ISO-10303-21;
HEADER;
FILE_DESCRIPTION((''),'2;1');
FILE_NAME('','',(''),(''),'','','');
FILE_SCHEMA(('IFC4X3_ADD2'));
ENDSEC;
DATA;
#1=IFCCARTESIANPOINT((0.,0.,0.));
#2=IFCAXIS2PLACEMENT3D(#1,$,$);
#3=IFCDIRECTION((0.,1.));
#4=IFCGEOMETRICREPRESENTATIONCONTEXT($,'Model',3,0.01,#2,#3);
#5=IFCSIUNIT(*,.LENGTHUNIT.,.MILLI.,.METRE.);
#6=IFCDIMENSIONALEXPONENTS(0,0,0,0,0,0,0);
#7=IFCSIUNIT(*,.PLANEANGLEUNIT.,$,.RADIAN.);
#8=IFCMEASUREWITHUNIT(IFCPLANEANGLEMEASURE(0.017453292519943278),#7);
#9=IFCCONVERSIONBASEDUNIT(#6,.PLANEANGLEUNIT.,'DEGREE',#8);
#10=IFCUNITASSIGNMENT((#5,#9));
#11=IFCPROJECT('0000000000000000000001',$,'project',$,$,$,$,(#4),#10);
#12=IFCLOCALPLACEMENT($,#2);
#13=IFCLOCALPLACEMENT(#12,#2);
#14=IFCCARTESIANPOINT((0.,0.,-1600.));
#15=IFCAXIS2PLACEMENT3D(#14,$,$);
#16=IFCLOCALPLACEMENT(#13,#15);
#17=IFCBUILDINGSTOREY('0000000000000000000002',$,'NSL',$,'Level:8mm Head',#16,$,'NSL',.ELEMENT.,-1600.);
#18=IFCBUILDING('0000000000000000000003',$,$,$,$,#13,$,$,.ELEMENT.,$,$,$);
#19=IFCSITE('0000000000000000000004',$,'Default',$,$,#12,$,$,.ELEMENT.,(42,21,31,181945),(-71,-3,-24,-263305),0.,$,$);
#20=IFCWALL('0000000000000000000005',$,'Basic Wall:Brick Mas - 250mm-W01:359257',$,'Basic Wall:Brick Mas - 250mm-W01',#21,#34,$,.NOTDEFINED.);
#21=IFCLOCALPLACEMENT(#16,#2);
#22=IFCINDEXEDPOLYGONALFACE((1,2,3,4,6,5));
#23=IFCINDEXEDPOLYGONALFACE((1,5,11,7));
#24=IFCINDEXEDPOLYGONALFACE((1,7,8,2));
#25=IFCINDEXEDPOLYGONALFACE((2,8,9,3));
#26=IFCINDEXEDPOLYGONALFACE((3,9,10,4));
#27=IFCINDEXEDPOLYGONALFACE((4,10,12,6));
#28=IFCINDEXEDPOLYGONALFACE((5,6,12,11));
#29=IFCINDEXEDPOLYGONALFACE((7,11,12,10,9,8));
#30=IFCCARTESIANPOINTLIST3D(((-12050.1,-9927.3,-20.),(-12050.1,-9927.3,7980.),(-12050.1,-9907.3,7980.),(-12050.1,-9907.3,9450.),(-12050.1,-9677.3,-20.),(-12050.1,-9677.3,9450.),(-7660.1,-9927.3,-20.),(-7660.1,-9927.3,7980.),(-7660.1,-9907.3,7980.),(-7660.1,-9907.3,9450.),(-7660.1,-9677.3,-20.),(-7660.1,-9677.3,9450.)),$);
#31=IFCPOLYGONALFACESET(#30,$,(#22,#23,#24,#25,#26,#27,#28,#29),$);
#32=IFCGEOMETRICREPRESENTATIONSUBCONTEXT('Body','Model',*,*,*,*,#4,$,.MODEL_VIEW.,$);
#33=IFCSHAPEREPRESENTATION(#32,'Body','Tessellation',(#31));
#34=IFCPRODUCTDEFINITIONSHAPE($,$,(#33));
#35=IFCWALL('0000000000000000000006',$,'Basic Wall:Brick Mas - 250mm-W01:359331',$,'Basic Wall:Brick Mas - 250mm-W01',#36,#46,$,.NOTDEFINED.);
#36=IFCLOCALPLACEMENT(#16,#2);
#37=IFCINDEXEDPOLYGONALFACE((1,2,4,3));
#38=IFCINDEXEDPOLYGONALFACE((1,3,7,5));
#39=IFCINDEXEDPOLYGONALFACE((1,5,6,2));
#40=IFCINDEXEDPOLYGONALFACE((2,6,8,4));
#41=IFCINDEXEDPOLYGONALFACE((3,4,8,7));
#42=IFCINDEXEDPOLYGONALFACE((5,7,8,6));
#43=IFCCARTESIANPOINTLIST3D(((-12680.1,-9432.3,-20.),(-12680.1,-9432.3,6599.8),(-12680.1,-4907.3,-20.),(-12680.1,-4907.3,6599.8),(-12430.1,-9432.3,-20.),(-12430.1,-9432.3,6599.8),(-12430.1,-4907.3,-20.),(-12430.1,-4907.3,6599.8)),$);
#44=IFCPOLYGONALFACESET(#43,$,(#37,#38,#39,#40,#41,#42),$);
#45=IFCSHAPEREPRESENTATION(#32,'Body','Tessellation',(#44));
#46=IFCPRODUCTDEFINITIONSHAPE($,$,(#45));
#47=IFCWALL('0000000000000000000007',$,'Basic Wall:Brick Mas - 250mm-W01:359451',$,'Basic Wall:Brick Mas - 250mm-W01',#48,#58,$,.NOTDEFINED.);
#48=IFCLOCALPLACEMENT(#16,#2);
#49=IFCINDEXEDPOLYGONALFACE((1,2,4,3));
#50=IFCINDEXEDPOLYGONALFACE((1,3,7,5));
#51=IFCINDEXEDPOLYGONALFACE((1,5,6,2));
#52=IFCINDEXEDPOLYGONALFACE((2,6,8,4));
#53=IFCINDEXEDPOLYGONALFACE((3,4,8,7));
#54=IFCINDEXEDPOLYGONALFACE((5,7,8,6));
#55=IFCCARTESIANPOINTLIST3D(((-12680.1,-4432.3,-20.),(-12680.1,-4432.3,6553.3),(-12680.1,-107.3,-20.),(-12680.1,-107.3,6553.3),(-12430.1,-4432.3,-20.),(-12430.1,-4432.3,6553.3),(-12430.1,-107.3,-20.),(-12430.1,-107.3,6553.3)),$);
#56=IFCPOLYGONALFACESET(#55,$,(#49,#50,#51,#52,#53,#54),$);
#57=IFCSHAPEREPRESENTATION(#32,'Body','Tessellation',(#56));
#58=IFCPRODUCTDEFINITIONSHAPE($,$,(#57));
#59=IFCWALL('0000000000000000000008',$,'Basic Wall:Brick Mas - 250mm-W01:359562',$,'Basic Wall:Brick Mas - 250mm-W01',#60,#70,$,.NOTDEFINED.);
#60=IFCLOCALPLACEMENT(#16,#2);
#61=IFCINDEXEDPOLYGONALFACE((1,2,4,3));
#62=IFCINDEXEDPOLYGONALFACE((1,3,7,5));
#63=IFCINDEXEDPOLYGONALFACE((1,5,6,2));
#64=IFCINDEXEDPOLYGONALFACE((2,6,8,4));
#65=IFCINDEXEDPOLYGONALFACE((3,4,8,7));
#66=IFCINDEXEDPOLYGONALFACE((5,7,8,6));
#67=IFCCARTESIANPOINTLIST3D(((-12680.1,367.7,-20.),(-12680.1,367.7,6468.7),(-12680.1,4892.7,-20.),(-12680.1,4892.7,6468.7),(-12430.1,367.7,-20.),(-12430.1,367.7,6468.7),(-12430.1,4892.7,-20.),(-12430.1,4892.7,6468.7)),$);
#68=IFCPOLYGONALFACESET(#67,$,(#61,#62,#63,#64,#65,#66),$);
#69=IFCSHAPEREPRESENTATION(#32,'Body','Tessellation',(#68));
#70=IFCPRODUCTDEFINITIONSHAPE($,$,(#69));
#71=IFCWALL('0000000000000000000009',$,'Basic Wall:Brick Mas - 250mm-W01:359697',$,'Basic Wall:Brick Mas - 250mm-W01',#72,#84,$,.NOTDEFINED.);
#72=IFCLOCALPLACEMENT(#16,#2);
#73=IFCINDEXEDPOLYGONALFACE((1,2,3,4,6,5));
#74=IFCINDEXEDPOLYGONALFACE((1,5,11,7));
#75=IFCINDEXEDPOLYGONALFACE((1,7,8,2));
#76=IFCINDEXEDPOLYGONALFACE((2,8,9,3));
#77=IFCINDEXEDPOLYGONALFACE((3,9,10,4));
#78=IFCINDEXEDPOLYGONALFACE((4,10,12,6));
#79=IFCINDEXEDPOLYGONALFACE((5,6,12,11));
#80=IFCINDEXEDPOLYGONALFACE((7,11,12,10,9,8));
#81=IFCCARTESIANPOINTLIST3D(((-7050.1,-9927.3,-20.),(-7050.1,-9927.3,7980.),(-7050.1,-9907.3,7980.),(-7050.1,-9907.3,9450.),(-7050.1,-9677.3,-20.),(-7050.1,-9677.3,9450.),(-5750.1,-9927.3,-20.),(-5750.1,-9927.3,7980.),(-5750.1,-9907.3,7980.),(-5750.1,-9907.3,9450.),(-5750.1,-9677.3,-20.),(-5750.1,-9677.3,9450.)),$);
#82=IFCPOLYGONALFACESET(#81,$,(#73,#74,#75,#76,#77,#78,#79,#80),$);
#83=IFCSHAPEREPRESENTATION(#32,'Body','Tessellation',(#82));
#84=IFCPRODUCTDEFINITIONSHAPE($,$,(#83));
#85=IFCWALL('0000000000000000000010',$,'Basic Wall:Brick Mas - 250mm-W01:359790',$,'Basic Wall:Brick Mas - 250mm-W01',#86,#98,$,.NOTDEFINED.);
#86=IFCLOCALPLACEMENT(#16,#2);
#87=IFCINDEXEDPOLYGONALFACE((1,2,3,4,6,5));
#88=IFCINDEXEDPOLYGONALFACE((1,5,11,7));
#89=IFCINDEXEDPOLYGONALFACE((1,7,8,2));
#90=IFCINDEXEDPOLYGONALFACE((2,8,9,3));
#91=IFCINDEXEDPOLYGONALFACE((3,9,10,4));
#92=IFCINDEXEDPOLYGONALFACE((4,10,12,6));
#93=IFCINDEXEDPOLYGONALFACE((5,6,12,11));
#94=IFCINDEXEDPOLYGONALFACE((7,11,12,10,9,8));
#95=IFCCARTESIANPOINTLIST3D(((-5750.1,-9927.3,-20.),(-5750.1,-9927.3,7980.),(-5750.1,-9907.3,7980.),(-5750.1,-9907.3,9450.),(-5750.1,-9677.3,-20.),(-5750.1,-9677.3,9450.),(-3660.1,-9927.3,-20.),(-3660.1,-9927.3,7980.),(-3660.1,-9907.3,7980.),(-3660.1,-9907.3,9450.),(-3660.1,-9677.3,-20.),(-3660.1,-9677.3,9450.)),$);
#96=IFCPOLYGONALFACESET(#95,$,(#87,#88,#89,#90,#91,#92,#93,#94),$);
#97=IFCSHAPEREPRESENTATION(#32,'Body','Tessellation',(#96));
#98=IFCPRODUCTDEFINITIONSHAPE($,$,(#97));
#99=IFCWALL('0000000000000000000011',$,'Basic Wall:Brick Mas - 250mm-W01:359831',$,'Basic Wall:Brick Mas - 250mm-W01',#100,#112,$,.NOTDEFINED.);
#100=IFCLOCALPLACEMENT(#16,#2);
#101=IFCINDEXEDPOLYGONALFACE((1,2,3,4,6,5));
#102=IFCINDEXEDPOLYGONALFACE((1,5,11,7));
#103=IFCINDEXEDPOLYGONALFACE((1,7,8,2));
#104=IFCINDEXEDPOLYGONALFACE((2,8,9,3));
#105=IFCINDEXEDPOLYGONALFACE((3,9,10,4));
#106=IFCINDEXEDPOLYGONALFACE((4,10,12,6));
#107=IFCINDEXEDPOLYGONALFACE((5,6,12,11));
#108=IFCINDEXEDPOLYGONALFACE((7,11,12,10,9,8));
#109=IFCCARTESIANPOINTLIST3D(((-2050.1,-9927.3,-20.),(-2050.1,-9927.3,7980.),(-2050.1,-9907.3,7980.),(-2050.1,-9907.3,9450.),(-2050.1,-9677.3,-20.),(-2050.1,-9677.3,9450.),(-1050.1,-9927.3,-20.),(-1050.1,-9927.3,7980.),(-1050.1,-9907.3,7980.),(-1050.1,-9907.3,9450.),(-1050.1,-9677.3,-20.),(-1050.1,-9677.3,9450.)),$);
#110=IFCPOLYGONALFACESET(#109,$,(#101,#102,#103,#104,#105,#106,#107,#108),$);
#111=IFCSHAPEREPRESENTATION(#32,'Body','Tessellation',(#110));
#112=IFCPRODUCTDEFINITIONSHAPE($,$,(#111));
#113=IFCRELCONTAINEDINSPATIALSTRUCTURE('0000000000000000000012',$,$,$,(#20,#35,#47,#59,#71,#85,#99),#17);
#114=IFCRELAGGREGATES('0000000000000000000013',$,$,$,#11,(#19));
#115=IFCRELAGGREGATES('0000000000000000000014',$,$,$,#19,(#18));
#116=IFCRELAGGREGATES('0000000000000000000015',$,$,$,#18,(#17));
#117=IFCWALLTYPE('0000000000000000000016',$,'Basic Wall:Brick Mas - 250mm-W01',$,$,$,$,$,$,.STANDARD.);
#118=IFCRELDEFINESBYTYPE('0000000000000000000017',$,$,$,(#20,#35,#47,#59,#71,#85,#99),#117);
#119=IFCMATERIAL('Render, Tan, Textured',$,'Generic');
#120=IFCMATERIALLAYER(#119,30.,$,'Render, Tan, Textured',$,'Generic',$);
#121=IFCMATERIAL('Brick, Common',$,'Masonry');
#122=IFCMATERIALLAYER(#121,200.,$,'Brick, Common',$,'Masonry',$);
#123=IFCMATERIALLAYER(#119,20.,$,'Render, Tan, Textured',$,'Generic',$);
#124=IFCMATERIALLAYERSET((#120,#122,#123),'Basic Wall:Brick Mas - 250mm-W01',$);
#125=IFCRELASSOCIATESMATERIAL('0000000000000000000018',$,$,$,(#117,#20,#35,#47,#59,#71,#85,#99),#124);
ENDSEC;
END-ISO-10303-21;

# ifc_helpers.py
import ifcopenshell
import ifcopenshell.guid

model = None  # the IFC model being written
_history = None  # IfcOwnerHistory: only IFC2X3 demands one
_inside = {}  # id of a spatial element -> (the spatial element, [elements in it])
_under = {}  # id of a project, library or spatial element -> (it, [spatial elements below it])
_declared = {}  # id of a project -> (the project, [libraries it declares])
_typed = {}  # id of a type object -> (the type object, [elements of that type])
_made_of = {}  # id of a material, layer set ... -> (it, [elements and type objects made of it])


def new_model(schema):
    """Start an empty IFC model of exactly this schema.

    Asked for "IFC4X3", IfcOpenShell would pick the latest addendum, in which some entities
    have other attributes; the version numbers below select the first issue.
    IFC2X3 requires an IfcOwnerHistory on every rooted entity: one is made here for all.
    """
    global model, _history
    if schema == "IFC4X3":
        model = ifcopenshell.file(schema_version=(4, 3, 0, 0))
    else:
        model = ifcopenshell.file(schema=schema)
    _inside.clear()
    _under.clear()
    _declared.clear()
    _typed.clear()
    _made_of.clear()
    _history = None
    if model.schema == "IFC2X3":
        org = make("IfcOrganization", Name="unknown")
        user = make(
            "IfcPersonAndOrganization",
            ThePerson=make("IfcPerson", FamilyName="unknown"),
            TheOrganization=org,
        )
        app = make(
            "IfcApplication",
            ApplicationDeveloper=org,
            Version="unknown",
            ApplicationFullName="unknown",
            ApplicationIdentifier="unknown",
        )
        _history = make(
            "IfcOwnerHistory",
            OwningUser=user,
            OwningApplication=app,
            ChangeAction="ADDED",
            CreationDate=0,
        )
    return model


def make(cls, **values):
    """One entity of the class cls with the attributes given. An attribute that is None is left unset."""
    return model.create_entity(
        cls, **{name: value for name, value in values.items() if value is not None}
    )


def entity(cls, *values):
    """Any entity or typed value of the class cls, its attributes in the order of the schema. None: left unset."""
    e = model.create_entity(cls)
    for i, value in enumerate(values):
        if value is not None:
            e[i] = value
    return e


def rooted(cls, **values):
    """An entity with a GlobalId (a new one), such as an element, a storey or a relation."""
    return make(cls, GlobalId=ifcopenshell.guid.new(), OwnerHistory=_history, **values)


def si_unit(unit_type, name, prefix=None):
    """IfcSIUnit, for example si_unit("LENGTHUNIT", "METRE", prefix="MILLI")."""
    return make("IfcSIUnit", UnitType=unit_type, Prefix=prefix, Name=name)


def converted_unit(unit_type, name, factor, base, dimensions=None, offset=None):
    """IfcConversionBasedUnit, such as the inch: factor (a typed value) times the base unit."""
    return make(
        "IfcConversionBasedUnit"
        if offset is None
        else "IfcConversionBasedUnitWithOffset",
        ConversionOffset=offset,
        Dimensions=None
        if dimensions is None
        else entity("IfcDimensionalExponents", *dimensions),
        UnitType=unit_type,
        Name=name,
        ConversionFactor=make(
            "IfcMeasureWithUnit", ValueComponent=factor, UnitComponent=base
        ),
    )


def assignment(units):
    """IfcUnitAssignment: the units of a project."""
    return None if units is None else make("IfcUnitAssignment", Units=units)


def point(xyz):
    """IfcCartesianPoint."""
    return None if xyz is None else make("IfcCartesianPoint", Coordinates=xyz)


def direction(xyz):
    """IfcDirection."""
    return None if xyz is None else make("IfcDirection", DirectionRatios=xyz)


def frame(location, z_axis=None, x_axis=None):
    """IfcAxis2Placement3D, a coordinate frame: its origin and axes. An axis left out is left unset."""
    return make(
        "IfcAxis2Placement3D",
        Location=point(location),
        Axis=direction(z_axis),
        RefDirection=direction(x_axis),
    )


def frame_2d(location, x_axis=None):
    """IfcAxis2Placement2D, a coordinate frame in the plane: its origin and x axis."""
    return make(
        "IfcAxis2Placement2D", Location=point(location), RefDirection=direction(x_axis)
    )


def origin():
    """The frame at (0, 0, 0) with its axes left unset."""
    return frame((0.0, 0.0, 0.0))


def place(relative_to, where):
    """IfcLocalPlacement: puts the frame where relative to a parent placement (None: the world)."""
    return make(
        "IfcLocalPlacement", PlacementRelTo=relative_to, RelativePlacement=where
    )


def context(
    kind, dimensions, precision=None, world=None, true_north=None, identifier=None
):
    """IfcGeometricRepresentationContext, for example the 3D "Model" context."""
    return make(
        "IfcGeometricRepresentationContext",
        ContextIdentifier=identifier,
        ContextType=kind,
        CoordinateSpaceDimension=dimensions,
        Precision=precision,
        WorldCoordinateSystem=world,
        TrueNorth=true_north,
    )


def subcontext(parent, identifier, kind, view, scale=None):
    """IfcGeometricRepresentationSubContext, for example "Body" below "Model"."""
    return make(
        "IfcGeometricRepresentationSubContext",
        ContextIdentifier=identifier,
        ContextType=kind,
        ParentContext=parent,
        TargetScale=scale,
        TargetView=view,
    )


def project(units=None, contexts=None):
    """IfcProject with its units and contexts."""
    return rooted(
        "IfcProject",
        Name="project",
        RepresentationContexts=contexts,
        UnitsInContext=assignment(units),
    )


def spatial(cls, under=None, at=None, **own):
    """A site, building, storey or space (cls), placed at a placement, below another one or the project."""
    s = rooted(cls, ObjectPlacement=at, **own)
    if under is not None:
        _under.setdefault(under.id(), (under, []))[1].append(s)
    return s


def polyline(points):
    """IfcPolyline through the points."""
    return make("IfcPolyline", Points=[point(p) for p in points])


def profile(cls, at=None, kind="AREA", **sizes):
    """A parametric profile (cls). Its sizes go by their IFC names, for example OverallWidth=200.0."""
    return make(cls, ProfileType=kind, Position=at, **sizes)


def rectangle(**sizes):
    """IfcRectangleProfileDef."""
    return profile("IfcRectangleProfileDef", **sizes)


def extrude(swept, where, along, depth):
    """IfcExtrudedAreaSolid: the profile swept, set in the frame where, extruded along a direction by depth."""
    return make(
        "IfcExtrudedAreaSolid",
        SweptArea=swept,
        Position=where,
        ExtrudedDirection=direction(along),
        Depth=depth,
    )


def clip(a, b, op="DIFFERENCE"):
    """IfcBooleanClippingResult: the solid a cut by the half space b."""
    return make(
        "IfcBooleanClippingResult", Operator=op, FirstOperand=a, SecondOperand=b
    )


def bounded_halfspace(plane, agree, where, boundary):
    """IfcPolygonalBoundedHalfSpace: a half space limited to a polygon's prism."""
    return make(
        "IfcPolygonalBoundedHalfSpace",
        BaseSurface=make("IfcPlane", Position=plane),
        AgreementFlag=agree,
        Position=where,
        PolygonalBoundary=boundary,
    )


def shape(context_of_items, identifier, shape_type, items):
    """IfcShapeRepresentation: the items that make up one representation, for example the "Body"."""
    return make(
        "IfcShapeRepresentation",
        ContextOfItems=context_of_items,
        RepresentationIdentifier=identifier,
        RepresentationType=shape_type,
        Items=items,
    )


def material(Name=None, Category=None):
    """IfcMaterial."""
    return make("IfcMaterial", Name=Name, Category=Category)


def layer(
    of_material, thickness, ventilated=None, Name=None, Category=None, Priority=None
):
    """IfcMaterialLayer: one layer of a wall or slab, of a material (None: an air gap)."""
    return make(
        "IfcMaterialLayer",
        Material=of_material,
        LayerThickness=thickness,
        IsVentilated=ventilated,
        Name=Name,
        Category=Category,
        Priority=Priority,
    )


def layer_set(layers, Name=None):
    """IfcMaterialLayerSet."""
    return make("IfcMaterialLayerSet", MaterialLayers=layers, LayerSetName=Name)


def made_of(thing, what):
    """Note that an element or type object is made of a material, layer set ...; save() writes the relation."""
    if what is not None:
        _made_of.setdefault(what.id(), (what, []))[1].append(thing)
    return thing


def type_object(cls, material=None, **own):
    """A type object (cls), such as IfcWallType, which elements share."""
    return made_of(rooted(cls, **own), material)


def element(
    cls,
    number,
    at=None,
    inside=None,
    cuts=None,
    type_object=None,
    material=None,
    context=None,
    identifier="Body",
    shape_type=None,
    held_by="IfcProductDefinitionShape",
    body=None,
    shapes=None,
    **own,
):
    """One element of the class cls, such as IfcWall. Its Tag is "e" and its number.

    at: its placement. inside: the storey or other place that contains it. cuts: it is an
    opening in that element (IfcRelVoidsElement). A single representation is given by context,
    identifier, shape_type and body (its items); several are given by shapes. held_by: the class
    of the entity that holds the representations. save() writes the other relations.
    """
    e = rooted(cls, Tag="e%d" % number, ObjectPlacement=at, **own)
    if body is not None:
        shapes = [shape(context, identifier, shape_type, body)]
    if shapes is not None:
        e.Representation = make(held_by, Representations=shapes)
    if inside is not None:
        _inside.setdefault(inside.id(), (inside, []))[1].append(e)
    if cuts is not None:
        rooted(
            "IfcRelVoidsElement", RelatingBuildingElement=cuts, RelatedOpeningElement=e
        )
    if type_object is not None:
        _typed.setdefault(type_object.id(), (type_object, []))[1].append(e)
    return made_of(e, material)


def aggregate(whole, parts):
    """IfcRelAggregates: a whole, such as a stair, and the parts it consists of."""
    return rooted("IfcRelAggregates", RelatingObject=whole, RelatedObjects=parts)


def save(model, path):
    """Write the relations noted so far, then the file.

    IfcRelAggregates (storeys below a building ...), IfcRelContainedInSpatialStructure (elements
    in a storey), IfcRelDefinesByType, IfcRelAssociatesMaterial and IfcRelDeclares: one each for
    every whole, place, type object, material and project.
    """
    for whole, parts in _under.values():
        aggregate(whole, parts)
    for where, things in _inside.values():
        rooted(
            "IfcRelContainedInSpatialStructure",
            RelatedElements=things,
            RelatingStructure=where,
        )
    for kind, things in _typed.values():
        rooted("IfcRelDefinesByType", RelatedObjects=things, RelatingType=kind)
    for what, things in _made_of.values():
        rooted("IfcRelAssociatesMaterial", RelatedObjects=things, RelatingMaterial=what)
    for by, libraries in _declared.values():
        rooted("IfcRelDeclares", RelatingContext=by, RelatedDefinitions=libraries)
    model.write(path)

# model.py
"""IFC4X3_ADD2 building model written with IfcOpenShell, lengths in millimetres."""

from ifc_helpers import new_model, entity, si_unit, converted_unit, direction, frame, frame_2d, origin, place, context, subcontext, project, spatial, polyline, rectangle, extrude, clip, bounded_halfspace, material, layer, layer_set, type_object, element, save


model = new_model("IFC4X3_ADD2")

# Units and contexts
model_context = context("Model", 3, precision=0.01, world=origin(), true_north=direction((0.0, 1.0)))
body_context = subcontext(model_context, "Body", "Model", "MODEL_VIEW")
ifc_project = project(units=[si_unit("LENGTHUNIT", "METRE", prefix="MILLI"), converted_unit("PLANEANGLEUNIT", "DEGREE", entity("IfcPlaneAngleMeasure", 0.017453292519943278), si_unit("PLANEANGLEUNIT", "RADIAN"), dimensions=[0, 0, 0, 0, 0, 0, 0])], contexts=[model_context])

# Site, building, storey
site_placement = place(None, origin())
site = spatial("IfcSite", under=ifc_project, at=site_placement, Name="Default", CompositionType="ELEMENT", RefLatitude=(42, 21, 31, 181945), RefLongitude=(-71, -3, -24, -263305), RefElevation=0.0)
building_placement = place(site_placement, origin())
building = spatial("IfcBuilding", under=site, at=building_placement, CompositionType="ELEMENT")
storey_placement = place(building_placement, frame((0.0, 0.0, -1600.0)))
storey = spatial("IfcBuildingStorey", under=building, at=storey_placement, Name="NSL", ObjectType="Level:8mm Head", LongName="NSL", CompositionType="ELEMENT", Elevation=-1600.0)

# Shared definitions
ifc_material_1 = material(Name="Render, Tan, Textured", Category="Generic")
ifc_layer_1 = layer(ifc_material_1, 30.0, Name="Render, Tan, Textured", Category="Generic")
ifc_material_2 = material(Name="Brick, Common", Category="Masonry")
ifc_layer_2 = layer(ifc_material_2, 200.0, Name="Brick, Common", Category="Masonry")
ifc_layer_3 = layer(ifc_material_1, 20.0, Name="Render, Tan, Textured", Category="Generic")
ifc_layer_set = layer_set([ifc_layer_1, ifc_layer_2, ifc_layer_3], Name="Basic Wall:Brick Mas - 250mm-W01")
wall_type = type_object("IfcWallType", Name="Basic Wall:Brick Mas - 250mm-W01", PredefinedType="STANDARD", material=ifc_layer_set)

# Walls
wall_1_placement = place(storey_placement, frame((-7660.1, -9802.3, -20.0), z_axis=(0.0, 0.0, 1.0), x_axis=(-1.0, 0.0, 0.0)))
element("IfcWall", 1, at=wall_1_placement, inside=storey, type_object=wall_type, material=ifc_layer_set, Name="Basic Wall:Brick Mas - 250mm-W01:359257", ObjectType="Basic Wall:Brick Mas - 250mm-W01", PredefinedType="NOTDEFINED", context=body_context, shape_type="Clipping", body=[
    clip(clip(extrude(rectangle(XDim=4390.0, YDim=250.0, at=frame_2d((2195.0, 0.0), x_axis=(-1.0, 0.0))), origin(), (0.0, 0.0, 1.0), 9470.0), bounded_halfspace(frame((0.0, -125.0, 9470.0), z_axis=(0.0, 0.0, -1.0), x_axis=(0.0, 1.0, 0.0)), True, frame((0.0, -125.0, 9470.0)), polyline([(0.0, 0.0), (4390.0, 0.0), (4390.0, 230.0), (0.0, 230.0), (0.0, 0.0)]))), bounded_halfspace(frame((4390.0, 105.0, 8000.0), z_axis=(0.0, 0.0, 1.0), x_axis=(0.0, 1.0, 0.0)), False, frame((4390.0, 105.0, 8000.0)), polyline([(0.0, 0.0), (0.0, 20.0), (-4390.0, 20.0), (-4390.0, 0.0), (0.0, 0.0)]))),
])
wall_2_placement = place(storey_placement, frame((-12555.1, -9432.3, -20.0), z_axis=(0.0, 0.0, 1.0), x_axis=(0.0, 1.0, 0.0)))
element("IfcWall", 2, at=wall_2_placement, inside=storey, type_object=wall_type, material=ifc_layer_set, Name="Basic Wall:Brick Mas - 250mm-W01:359331", ObjectType="Basic Wall:Brick Mas - 250mm-W01", PredefinedType="NOTDEFINED", context=body_context, shape_type="SweptSolid", body=[
    extrude(rectangle(XDim=4525.0, YDim=250.0, at=frame_2d((2262.5, 0.0), x_axis=(-1.0, 0.0))), origin(), (0.0, 0.0, 1.0), 6619.8),
])
wall_3_placement = place(storey_placement, frame((-12555.1, -4432.3, -20.0), z_axis=(0.0, 0.0, 1.0), x_axis=(0.0, 1.0, 0.0)))
element("IfcWall", 3, at=wall_3_placement, inside=storey, type_object=wall_type, material=ifc_layer_set, Name="Basic Wall:Brick Mas - 250mm-W01:359451", ObjectType="Basic Wall:Brick Mas - 250mm-W01", PredefinedType="NOTDEFINED", context=body_context, shape_type="SweptSolid", body=[
    extrude(rectangle(XDim=4325.0, YDim=250.0, at=frame_2d((2162.5, 0.0), x_axis=(-1.0, 0.0))), origin(), (0.0, 0.0, 1.0), 6573.3),
])
wall_4_placement = place(storey_placement, frame((-12555.1, 367.7, -20.0), z_axis=(0.0, 0.0, 1.0), x_axis=(0.0, 1.0, 0.0)))
element("IfcWall", 4, at=wall_4_placement, inside=storey, type_object=wall_type, material=ifc_layer_set, Name="Basic Wall:Brick Mas - 250mm-W01:359562", ObjectType="Basic Wall:Brick Mas - 250mm-W01", PredefinedType="NOTDEFINED", context=body_context, shape_type="SweptSolid", body=[
    extrude(rectangle(XDim=4525.0, YDim=250.0, at=frame_2d((2262.5, 0.0), x_axis=(-1.0, 0.0))), origin(), (0.0, 0.0, 1.0), 6488.7),
])
wall_5_placement = place(storey_placement, frame((-5750.1, -9802.3, -20.0), z_axis=(0.0, 0.0, 1.0), x_axis=(-1.0, 0.0, 0.0)))
element("IfcWall", 5, at=wall_5_placement, inside=storey, type_object=wall_type, material=ifc_layer_set, Name="Basic Wall:Brick Mas - 250mm-W01:359697", ObjectType="Basic Wall:Brick Mas - 250mm-W01", PredefinedType="NOTDEFINED", context=body_context, shape_type="Clipping", body=[
    clip(clip(extrude(rectangle(XDim=1300.0, YDim=250.0, at=frame_2d((650.0, 0.0), x_axis=(-1.0, 0.0))), origin(), (0.0, 0.0, 1.0), 9470.0), bounded_halfspace(frame((0.0, -125.0, 9470.0), z_axis=(0.0, 0.0, -1.0), x_axis=(0.0, 1.0, 0.0)), True, frame((0.0, -125.0, 9470.0)), polyline([(0.0, 0.0), (1300.0, 0.0), (1300.0, 230.0), (0.0, 230.0), (0.0, 0.0)]))), bounded_halfspace(frame((1300.0, 105.0, 8000.0), z_axis=(0.0, 0.0, 1.0), x_axis=(0.0, 1.0, 0.0)), False, frame((1300.0, 105.0, 8000.0)), polyline([(0.0, 0.0), (0.0, 20.0), (-1300.0, 20.0), (-1300.0, 0.0), (0.0, 0.0)]))),
])
wall_6_placement = place(storey_placement, frame((-3660.1, -9802.3, -20.0), z_axis=(0.0, 0.0, 1.0), x_axis=(-1.0, 0.0, 0.0)))
element("IfcWall", 6, at=wall_6_placement, inside=storey, type_object=wall_type, material=ifc_layer_set, Name="Basic Wall:Brick Mas - 250mm-W01:359790", ObjectType="Basic Wall:Brick Mas - 250mm-W01", PredefinedType="NOTDEFINED", context=body_context, shape_type="Clipping", body=[
    clip(clip(extrude(rectangle(XDim=2090.0, YDim=250.0, at=frame_2d((1045.0, 0.0), x_axis=(-1.0, 0.0))), origin(), (0.0, 0.0, 1.0), 9470.0), bounded_halfspace(frame((0.0, -125.0, 9470.0), z_axis=(0.0, 0.0, -1.0), x_axis=(0.0, 1.0, 0.0)), True, frame((0.0, -125.0, 9470.0)), polyline([(0.0, 0.0), (2090.0, 0.0), (2090.0, 230.0), (0.0, 230.0), (0.0, 0.0)]))), bounded_halfspace(frame((2090.0, 105.0, 8000.0), z_axis=(0.0, 0.0, 1.0), x_axis=(0.0, 1.0, 0.0)), False, frame((2090.0, 105.0, 8000.0)), polyline([(0.0, 0.0), (0.0, 20.0), (-2090.0, 20.0), (-2090.0, 0.0), (0.0, 0.0)]))),
])
wall_7_placement = place(storey_placement, frame((-1050.1, -9802.3, -20.0), z_axis=(0.0, 0.0, 1.0), x_axis=(-1.0, 0.0, 0.0)))
element("IfcWall", 7, at=wall_7_placement, inside=storey, type_object=wall_type, material=ifc_layer_set, Name="Basic Wall:Brick Mas - 250mm-W01:359831", ObjectType="Basic Wall:Brick Mas - 250mm-W01", PredefinedType="NOTDEFINED", context=body_context, shape_type="Clipping", body=[
    clip(clip(extrude(rectangle(XDim=1000.0, YDim=250.0, at=frame_2d((500.0, 0.0), x_axis=(-1.0, 0.0))), origin(), (0.0, 0.0, 1.0), 9470.0), bounded_halfspace(frame((0.0, -125.0, 9470.0), z_axis=(0.0, 0.0, -1.0), x_axis=(0.0, 1.0, 0.0)), True, frame((0.0, -125.0, 9470.0)), polyline([(0.0, 0.0), (1000.0, 0.0), (1000.0, 230.0), (0.0, 230.0), (0.0, 0.0)]))), bounded_halfspace(frame((1000.0, 105.0, 8000.0), z_axis=(0.0, 0.0, 1.0), x_axis=(0.0, 1.0, 0.0)), False, frame((1000.0, 105.0, 8000.0)), polyline([(0.0, 0.0), (0.0, 20.0), (-1000.0, 20.0), (-1000.0, 0.0), (0.0, 0.0)]))),
])

save(model, "model.ifc")
